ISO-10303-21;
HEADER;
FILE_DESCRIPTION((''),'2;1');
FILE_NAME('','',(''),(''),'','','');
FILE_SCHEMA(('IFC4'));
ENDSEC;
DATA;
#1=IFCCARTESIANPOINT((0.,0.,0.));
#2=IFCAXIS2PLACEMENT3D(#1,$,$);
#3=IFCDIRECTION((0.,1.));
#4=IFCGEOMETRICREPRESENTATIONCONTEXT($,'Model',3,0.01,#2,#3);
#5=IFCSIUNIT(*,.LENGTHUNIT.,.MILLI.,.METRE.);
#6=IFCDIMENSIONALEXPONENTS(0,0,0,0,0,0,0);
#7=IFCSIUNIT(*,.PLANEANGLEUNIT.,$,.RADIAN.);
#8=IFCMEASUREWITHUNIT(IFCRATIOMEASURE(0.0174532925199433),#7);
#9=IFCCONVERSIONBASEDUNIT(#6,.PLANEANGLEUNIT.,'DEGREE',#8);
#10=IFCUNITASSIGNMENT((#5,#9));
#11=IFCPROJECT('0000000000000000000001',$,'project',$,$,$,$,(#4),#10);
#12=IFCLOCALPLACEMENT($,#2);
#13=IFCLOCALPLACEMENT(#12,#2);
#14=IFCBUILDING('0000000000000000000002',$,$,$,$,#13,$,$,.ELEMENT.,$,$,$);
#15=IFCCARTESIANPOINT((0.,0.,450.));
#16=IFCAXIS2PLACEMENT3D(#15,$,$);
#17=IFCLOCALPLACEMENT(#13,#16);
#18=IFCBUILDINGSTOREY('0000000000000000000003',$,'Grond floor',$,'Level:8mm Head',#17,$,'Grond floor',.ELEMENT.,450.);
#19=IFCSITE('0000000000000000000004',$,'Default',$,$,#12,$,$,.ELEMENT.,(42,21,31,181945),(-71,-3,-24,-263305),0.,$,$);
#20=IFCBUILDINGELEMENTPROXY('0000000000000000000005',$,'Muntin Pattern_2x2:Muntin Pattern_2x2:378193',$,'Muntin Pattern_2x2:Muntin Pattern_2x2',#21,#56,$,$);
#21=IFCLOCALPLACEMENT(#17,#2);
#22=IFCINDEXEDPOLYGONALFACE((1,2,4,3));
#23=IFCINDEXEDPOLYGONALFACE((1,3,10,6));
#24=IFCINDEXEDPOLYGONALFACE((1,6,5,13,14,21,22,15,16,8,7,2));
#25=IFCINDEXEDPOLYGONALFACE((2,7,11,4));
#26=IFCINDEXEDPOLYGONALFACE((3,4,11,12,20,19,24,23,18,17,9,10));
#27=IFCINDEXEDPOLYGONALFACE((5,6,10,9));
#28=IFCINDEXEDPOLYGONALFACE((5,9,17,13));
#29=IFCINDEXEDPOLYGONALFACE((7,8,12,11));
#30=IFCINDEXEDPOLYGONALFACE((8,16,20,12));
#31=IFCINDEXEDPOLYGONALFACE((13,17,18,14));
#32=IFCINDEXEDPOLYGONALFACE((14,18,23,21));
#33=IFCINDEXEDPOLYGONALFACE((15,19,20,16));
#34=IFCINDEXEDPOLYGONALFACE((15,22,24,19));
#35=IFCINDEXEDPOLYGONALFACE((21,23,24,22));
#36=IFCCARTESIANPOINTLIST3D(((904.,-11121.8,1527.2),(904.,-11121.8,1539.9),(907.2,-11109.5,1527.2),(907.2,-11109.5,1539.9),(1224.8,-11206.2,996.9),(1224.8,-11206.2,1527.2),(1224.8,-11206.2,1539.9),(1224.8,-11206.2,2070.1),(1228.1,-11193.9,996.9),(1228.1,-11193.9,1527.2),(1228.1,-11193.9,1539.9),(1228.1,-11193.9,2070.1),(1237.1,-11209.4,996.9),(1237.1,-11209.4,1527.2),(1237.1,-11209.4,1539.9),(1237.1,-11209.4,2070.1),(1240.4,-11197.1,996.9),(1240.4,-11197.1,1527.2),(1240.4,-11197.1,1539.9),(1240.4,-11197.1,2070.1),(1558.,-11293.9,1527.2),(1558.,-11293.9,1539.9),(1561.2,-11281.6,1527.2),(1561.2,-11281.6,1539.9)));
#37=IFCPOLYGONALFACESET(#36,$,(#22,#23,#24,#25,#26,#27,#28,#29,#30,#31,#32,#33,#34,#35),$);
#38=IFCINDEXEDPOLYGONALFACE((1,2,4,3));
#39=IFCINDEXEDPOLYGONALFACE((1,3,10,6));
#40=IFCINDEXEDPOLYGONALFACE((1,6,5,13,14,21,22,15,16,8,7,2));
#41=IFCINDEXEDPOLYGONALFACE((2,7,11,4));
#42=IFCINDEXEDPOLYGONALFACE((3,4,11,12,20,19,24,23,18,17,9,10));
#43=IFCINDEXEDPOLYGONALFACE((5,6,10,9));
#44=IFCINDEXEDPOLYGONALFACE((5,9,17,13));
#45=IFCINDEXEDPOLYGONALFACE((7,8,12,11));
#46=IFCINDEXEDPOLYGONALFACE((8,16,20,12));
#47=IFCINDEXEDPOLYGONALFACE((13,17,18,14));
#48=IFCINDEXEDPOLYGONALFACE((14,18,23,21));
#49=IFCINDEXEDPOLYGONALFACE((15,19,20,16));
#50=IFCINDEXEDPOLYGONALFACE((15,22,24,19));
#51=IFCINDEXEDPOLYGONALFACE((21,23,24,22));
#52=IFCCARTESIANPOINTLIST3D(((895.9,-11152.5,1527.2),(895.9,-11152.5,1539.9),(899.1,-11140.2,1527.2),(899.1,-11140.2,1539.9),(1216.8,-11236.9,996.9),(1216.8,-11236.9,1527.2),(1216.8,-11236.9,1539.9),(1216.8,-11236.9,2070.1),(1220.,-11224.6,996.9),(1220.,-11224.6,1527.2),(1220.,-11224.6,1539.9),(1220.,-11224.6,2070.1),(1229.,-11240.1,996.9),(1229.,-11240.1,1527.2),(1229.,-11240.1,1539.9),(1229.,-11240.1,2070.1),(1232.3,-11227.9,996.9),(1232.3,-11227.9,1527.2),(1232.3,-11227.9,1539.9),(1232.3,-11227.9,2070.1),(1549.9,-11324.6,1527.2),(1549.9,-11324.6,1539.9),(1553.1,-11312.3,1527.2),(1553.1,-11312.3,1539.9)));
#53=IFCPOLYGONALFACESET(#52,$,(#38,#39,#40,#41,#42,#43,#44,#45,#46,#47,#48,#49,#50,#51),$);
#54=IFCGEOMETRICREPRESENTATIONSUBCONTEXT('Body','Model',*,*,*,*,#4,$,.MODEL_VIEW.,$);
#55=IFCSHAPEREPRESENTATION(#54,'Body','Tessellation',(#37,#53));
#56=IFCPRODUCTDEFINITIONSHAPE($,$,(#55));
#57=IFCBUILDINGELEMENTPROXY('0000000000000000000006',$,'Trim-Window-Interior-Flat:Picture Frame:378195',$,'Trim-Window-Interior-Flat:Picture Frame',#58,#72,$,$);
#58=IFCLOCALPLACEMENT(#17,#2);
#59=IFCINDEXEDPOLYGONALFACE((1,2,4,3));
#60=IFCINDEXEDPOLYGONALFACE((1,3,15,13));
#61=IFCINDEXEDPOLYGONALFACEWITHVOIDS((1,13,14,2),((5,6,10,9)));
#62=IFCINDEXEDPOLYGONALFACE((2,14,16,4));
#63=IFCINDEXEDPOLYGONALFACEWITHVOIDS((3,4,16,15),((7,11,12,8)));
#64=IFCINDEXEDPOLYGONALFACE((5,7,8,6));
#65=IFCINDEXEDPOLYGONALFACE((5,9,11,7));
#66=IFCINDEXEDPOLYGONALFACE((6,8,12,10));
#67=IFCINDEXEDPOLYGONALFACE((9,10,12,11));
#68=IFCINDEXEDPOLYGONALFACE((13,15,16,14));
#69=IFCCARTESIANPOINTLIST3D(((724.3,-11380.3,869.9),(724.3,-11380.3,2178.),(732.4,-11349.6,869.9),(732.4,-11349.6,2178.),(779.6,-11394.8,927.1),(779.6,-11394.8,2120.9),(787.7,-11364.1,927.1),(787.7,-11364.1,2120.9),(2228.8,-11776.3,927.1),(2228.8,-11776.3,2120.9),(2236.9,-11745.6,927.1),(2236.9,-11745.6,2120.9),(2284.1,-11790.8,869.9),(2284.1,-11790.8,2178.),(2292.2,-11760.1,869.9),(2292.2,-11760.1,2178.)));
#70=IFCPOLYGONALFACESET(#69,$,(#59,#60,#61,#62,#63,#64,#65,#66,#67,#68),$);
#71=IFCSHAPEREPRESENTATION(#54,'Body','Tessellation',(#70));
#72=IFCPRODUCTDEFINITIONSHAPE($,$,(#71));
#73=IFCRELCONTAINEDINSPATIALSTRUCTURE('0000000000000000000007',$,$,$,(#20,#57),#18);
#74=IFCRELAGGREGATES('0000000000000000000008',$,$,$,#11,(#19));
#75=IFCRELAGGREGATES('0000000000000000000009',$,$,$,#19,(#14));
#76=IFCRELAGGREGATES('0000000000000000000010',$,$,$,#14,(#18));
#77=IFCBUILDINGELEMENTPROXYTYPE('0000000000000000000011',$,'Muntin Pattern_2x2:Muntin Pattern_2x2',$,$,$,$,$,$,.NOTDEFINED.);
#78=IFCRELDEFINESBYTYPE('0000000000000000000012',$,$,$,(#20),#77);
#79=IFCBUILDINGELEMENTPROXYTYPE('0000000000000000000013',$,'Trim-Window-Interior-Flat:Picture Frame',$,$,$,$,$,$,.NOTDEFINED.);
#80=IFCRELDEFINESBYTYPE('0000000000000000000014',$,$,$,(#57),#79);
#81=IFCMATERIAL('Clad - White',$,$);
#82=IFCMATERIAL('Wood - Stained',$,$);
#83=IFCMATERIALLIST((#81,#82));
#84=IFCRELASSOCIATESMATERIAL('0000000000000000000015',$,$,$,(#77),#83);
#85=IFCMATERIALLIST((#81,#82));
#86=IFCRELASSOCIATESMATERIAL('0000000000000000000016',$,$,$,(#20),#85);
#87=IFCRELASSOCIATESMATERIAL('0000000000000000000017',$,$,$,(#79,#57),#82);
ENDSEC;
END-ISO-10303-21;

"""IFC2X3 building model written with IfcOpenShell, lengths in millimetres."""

from ifc_helpers import new_model, entity, si_unit, converted_unit, direction, frame, origin, place, context, subcontext, project, spatial, polyline, outline, extrude, source, transform, mapped, material, material_list, type_object, type_shapes, element, save


model = new_model("IFC2X3")

# Units and contexts
model_context = context("Model", 3, precision=0.01, world=origin(), true_north=direction((0.0, 1.0)))
body_context = subcontext(model_context, "Body", "Model", "MODEL_VIEW")
ifc_project = project(units=[si_unit("LENGTHUNIT", "METRE", prefix="MILLI"), converted_unit("PLANEANGLEUNIT", "DEGREE", entity("IfcRatioMeasure", 0.0174532925199433), si_unit("PLANEANGLEUNIT", "RADIAN"), dimensions=[0, 0, 0, 0, 0, 0, 0])], contexts=[model_context])

# Site, building, storey
site_placement = place(None, origin())
site = spatial("IfcSite", under=ifc_project, at=site_placement, Name="Default", CompositionType="ELEMENT", RefLatitude=(42, 21, 31, 181945), RefLongitude=(-71, -3, -24, -263305), RefElevation=0.0)
building_placement = place(site_placement, origin())
building = spatial("IfcBuilding", under=site, at=building_placement, CompositionType="ELEMENT")
storey_placement = place(building_placement, frame((0.0, 0.0, 450.0)))
storey = spatial("IfcBuildingStorey", under=building, at=storey_placement, Name="Grond floor", ObjectType="Level:8mm Head", LongName="Grond floor", CompositionType="ELEMENT", Elevation=450.0)

# Building element proxies
ifc_material_1 = material(Name="Clad - White")
ifc_material_2 = material(Name="Wood - Stained")
ifc_material_list_1 = material_list([ifc_material_1, ifc_material_2])
building_element_proxy_type_1 = type_object("IfcBuildingElementProxyType", Name="Muntin Pattern_2x2:Muntin Pattern_2x2", PredefinedType="NOTDEFINED", material=ifc_material_list_1)
shared_shape_1 = source(origin(), body_context, "Body", "SweptSolid", [
    extrude(outline(polyline([(6.4, -6.4), (536.6, -6.4), (536.6, 6.3), (6.4, 6.3), (6.4, 338.1), (-6.3, 338.1), (-6.3, 6.3), (-536.6, 6.3), (-536.6, -6.4), (-6.3, -6.4), (-6.3, -338.1), (6.4, -338.1), (6.4, -6.4)])), frame((0.0, 9.5, 536.6), z_axis=(0.0, 1.0, 0.0), x_axis=(0.0, 0.0, 1.0)), (0.0, 0.0, 1.0), 12.7),
    extrude(outline(polyline([(6.4, -6.4), (536.6, -6.4), (536.6, 6.3), (6.4, 6.3), (6.4, 338.1), (-6.3, 338.1), (-6.3, 6.3), (-536.6, 6.3), (-536.6, -6.4), (-6.3, -6.4), (-6.3, -338.1), (6.4, -338.1), (6.4, -6.4)])), frame((0.0, -22.2, 536.6), z_axis=(0.0, 1.0, 0.0), x_axis=(0.0, 0.0, 1.0)), (0.0, 0.0, 1.0), 12.7),
])
type_shapes(building_element_proxy_type_1, [shared_shape_1])
ifc_material_list_2 = material_list([ifc_material_1, ifc_material_2])
proxy_1_placement = place(storey_placement, frame((1228.6, -11217.0, 996.9), z_axis=(0.0, 0.0, 1.0), x_axis=(0.967067, -0.25452, 0.0)))
element("IfcBuildingElementProxy", 1, at=proxy_1_placement, inside=storey, type_object=building_element_proxy_type_1, material=ifc_material_list_2, Name="Muntin Pattern_2x2:Muntin Pattern_2x2:378193", ObjectType="Muntin Pattern_2x2:Muntin Pattern_2x2", context=body_context, shape_type="MappedRepresentation", body=[
    mapped(shared_shape_1, transform((0.0, 0.0, 0.0), scale=1.0)),
])
building_element_proxy_type_2 = type_object("IfcBuildingElementProxyType", Name="Trim-Window-Interior-Flat:Picture Frame", PredefinedType="NOTDEFINED", material=ifc_material_2)
shared_shape_2 = source(origin(), body_context, "Body", "SweptSolid", [
    extrude(outline(polyline([(-806.4, -654.0), (806.4, -654.0), (806.4, 654.0), (-806.4, 654.0), (-806.4, -654.0)]), holes=[polyline([(-749.3, -596.9), (-749.3, 596.9), (749.3, 596.9), (749.3, -596.9), (-749.3, -596.9)])]), frame((0.0, -609.6, 0.0), z_axis=(0.0, 0.0, 1.0), x_axis=(-1.0, 0.0, 0.0)), (0.0, 0.0, 1.0), 31.8),
])
type_shapes(building_element_proxy_type_2, [shared_shape_2])
proxy_2_placement = place(storey_placement, frame((1512.3, -11554.8, 2133.6), z_axis=(-0.25452, -0.967067, 0.0), x_axis=(0.967067, -0.25452, 0.0)))
element("IfcBuildingElementProxy", 2, at=proxy_2_placement, inside=storey, type_object=building_element_proxy_type_2, material=ifc_material_2, Name="Trim-Window-Interior-Flat:Picture Frame:378195", ObjectType="Trim-Window-Interior-Flat:Picture Frame", context=body_context, shape_type="MappedRepresentation", body=[
    mapped(shared_shape_2, transform((0.0, 0.0, 0.0), scale=1.0)),
])

save(model, "model.ifc")
